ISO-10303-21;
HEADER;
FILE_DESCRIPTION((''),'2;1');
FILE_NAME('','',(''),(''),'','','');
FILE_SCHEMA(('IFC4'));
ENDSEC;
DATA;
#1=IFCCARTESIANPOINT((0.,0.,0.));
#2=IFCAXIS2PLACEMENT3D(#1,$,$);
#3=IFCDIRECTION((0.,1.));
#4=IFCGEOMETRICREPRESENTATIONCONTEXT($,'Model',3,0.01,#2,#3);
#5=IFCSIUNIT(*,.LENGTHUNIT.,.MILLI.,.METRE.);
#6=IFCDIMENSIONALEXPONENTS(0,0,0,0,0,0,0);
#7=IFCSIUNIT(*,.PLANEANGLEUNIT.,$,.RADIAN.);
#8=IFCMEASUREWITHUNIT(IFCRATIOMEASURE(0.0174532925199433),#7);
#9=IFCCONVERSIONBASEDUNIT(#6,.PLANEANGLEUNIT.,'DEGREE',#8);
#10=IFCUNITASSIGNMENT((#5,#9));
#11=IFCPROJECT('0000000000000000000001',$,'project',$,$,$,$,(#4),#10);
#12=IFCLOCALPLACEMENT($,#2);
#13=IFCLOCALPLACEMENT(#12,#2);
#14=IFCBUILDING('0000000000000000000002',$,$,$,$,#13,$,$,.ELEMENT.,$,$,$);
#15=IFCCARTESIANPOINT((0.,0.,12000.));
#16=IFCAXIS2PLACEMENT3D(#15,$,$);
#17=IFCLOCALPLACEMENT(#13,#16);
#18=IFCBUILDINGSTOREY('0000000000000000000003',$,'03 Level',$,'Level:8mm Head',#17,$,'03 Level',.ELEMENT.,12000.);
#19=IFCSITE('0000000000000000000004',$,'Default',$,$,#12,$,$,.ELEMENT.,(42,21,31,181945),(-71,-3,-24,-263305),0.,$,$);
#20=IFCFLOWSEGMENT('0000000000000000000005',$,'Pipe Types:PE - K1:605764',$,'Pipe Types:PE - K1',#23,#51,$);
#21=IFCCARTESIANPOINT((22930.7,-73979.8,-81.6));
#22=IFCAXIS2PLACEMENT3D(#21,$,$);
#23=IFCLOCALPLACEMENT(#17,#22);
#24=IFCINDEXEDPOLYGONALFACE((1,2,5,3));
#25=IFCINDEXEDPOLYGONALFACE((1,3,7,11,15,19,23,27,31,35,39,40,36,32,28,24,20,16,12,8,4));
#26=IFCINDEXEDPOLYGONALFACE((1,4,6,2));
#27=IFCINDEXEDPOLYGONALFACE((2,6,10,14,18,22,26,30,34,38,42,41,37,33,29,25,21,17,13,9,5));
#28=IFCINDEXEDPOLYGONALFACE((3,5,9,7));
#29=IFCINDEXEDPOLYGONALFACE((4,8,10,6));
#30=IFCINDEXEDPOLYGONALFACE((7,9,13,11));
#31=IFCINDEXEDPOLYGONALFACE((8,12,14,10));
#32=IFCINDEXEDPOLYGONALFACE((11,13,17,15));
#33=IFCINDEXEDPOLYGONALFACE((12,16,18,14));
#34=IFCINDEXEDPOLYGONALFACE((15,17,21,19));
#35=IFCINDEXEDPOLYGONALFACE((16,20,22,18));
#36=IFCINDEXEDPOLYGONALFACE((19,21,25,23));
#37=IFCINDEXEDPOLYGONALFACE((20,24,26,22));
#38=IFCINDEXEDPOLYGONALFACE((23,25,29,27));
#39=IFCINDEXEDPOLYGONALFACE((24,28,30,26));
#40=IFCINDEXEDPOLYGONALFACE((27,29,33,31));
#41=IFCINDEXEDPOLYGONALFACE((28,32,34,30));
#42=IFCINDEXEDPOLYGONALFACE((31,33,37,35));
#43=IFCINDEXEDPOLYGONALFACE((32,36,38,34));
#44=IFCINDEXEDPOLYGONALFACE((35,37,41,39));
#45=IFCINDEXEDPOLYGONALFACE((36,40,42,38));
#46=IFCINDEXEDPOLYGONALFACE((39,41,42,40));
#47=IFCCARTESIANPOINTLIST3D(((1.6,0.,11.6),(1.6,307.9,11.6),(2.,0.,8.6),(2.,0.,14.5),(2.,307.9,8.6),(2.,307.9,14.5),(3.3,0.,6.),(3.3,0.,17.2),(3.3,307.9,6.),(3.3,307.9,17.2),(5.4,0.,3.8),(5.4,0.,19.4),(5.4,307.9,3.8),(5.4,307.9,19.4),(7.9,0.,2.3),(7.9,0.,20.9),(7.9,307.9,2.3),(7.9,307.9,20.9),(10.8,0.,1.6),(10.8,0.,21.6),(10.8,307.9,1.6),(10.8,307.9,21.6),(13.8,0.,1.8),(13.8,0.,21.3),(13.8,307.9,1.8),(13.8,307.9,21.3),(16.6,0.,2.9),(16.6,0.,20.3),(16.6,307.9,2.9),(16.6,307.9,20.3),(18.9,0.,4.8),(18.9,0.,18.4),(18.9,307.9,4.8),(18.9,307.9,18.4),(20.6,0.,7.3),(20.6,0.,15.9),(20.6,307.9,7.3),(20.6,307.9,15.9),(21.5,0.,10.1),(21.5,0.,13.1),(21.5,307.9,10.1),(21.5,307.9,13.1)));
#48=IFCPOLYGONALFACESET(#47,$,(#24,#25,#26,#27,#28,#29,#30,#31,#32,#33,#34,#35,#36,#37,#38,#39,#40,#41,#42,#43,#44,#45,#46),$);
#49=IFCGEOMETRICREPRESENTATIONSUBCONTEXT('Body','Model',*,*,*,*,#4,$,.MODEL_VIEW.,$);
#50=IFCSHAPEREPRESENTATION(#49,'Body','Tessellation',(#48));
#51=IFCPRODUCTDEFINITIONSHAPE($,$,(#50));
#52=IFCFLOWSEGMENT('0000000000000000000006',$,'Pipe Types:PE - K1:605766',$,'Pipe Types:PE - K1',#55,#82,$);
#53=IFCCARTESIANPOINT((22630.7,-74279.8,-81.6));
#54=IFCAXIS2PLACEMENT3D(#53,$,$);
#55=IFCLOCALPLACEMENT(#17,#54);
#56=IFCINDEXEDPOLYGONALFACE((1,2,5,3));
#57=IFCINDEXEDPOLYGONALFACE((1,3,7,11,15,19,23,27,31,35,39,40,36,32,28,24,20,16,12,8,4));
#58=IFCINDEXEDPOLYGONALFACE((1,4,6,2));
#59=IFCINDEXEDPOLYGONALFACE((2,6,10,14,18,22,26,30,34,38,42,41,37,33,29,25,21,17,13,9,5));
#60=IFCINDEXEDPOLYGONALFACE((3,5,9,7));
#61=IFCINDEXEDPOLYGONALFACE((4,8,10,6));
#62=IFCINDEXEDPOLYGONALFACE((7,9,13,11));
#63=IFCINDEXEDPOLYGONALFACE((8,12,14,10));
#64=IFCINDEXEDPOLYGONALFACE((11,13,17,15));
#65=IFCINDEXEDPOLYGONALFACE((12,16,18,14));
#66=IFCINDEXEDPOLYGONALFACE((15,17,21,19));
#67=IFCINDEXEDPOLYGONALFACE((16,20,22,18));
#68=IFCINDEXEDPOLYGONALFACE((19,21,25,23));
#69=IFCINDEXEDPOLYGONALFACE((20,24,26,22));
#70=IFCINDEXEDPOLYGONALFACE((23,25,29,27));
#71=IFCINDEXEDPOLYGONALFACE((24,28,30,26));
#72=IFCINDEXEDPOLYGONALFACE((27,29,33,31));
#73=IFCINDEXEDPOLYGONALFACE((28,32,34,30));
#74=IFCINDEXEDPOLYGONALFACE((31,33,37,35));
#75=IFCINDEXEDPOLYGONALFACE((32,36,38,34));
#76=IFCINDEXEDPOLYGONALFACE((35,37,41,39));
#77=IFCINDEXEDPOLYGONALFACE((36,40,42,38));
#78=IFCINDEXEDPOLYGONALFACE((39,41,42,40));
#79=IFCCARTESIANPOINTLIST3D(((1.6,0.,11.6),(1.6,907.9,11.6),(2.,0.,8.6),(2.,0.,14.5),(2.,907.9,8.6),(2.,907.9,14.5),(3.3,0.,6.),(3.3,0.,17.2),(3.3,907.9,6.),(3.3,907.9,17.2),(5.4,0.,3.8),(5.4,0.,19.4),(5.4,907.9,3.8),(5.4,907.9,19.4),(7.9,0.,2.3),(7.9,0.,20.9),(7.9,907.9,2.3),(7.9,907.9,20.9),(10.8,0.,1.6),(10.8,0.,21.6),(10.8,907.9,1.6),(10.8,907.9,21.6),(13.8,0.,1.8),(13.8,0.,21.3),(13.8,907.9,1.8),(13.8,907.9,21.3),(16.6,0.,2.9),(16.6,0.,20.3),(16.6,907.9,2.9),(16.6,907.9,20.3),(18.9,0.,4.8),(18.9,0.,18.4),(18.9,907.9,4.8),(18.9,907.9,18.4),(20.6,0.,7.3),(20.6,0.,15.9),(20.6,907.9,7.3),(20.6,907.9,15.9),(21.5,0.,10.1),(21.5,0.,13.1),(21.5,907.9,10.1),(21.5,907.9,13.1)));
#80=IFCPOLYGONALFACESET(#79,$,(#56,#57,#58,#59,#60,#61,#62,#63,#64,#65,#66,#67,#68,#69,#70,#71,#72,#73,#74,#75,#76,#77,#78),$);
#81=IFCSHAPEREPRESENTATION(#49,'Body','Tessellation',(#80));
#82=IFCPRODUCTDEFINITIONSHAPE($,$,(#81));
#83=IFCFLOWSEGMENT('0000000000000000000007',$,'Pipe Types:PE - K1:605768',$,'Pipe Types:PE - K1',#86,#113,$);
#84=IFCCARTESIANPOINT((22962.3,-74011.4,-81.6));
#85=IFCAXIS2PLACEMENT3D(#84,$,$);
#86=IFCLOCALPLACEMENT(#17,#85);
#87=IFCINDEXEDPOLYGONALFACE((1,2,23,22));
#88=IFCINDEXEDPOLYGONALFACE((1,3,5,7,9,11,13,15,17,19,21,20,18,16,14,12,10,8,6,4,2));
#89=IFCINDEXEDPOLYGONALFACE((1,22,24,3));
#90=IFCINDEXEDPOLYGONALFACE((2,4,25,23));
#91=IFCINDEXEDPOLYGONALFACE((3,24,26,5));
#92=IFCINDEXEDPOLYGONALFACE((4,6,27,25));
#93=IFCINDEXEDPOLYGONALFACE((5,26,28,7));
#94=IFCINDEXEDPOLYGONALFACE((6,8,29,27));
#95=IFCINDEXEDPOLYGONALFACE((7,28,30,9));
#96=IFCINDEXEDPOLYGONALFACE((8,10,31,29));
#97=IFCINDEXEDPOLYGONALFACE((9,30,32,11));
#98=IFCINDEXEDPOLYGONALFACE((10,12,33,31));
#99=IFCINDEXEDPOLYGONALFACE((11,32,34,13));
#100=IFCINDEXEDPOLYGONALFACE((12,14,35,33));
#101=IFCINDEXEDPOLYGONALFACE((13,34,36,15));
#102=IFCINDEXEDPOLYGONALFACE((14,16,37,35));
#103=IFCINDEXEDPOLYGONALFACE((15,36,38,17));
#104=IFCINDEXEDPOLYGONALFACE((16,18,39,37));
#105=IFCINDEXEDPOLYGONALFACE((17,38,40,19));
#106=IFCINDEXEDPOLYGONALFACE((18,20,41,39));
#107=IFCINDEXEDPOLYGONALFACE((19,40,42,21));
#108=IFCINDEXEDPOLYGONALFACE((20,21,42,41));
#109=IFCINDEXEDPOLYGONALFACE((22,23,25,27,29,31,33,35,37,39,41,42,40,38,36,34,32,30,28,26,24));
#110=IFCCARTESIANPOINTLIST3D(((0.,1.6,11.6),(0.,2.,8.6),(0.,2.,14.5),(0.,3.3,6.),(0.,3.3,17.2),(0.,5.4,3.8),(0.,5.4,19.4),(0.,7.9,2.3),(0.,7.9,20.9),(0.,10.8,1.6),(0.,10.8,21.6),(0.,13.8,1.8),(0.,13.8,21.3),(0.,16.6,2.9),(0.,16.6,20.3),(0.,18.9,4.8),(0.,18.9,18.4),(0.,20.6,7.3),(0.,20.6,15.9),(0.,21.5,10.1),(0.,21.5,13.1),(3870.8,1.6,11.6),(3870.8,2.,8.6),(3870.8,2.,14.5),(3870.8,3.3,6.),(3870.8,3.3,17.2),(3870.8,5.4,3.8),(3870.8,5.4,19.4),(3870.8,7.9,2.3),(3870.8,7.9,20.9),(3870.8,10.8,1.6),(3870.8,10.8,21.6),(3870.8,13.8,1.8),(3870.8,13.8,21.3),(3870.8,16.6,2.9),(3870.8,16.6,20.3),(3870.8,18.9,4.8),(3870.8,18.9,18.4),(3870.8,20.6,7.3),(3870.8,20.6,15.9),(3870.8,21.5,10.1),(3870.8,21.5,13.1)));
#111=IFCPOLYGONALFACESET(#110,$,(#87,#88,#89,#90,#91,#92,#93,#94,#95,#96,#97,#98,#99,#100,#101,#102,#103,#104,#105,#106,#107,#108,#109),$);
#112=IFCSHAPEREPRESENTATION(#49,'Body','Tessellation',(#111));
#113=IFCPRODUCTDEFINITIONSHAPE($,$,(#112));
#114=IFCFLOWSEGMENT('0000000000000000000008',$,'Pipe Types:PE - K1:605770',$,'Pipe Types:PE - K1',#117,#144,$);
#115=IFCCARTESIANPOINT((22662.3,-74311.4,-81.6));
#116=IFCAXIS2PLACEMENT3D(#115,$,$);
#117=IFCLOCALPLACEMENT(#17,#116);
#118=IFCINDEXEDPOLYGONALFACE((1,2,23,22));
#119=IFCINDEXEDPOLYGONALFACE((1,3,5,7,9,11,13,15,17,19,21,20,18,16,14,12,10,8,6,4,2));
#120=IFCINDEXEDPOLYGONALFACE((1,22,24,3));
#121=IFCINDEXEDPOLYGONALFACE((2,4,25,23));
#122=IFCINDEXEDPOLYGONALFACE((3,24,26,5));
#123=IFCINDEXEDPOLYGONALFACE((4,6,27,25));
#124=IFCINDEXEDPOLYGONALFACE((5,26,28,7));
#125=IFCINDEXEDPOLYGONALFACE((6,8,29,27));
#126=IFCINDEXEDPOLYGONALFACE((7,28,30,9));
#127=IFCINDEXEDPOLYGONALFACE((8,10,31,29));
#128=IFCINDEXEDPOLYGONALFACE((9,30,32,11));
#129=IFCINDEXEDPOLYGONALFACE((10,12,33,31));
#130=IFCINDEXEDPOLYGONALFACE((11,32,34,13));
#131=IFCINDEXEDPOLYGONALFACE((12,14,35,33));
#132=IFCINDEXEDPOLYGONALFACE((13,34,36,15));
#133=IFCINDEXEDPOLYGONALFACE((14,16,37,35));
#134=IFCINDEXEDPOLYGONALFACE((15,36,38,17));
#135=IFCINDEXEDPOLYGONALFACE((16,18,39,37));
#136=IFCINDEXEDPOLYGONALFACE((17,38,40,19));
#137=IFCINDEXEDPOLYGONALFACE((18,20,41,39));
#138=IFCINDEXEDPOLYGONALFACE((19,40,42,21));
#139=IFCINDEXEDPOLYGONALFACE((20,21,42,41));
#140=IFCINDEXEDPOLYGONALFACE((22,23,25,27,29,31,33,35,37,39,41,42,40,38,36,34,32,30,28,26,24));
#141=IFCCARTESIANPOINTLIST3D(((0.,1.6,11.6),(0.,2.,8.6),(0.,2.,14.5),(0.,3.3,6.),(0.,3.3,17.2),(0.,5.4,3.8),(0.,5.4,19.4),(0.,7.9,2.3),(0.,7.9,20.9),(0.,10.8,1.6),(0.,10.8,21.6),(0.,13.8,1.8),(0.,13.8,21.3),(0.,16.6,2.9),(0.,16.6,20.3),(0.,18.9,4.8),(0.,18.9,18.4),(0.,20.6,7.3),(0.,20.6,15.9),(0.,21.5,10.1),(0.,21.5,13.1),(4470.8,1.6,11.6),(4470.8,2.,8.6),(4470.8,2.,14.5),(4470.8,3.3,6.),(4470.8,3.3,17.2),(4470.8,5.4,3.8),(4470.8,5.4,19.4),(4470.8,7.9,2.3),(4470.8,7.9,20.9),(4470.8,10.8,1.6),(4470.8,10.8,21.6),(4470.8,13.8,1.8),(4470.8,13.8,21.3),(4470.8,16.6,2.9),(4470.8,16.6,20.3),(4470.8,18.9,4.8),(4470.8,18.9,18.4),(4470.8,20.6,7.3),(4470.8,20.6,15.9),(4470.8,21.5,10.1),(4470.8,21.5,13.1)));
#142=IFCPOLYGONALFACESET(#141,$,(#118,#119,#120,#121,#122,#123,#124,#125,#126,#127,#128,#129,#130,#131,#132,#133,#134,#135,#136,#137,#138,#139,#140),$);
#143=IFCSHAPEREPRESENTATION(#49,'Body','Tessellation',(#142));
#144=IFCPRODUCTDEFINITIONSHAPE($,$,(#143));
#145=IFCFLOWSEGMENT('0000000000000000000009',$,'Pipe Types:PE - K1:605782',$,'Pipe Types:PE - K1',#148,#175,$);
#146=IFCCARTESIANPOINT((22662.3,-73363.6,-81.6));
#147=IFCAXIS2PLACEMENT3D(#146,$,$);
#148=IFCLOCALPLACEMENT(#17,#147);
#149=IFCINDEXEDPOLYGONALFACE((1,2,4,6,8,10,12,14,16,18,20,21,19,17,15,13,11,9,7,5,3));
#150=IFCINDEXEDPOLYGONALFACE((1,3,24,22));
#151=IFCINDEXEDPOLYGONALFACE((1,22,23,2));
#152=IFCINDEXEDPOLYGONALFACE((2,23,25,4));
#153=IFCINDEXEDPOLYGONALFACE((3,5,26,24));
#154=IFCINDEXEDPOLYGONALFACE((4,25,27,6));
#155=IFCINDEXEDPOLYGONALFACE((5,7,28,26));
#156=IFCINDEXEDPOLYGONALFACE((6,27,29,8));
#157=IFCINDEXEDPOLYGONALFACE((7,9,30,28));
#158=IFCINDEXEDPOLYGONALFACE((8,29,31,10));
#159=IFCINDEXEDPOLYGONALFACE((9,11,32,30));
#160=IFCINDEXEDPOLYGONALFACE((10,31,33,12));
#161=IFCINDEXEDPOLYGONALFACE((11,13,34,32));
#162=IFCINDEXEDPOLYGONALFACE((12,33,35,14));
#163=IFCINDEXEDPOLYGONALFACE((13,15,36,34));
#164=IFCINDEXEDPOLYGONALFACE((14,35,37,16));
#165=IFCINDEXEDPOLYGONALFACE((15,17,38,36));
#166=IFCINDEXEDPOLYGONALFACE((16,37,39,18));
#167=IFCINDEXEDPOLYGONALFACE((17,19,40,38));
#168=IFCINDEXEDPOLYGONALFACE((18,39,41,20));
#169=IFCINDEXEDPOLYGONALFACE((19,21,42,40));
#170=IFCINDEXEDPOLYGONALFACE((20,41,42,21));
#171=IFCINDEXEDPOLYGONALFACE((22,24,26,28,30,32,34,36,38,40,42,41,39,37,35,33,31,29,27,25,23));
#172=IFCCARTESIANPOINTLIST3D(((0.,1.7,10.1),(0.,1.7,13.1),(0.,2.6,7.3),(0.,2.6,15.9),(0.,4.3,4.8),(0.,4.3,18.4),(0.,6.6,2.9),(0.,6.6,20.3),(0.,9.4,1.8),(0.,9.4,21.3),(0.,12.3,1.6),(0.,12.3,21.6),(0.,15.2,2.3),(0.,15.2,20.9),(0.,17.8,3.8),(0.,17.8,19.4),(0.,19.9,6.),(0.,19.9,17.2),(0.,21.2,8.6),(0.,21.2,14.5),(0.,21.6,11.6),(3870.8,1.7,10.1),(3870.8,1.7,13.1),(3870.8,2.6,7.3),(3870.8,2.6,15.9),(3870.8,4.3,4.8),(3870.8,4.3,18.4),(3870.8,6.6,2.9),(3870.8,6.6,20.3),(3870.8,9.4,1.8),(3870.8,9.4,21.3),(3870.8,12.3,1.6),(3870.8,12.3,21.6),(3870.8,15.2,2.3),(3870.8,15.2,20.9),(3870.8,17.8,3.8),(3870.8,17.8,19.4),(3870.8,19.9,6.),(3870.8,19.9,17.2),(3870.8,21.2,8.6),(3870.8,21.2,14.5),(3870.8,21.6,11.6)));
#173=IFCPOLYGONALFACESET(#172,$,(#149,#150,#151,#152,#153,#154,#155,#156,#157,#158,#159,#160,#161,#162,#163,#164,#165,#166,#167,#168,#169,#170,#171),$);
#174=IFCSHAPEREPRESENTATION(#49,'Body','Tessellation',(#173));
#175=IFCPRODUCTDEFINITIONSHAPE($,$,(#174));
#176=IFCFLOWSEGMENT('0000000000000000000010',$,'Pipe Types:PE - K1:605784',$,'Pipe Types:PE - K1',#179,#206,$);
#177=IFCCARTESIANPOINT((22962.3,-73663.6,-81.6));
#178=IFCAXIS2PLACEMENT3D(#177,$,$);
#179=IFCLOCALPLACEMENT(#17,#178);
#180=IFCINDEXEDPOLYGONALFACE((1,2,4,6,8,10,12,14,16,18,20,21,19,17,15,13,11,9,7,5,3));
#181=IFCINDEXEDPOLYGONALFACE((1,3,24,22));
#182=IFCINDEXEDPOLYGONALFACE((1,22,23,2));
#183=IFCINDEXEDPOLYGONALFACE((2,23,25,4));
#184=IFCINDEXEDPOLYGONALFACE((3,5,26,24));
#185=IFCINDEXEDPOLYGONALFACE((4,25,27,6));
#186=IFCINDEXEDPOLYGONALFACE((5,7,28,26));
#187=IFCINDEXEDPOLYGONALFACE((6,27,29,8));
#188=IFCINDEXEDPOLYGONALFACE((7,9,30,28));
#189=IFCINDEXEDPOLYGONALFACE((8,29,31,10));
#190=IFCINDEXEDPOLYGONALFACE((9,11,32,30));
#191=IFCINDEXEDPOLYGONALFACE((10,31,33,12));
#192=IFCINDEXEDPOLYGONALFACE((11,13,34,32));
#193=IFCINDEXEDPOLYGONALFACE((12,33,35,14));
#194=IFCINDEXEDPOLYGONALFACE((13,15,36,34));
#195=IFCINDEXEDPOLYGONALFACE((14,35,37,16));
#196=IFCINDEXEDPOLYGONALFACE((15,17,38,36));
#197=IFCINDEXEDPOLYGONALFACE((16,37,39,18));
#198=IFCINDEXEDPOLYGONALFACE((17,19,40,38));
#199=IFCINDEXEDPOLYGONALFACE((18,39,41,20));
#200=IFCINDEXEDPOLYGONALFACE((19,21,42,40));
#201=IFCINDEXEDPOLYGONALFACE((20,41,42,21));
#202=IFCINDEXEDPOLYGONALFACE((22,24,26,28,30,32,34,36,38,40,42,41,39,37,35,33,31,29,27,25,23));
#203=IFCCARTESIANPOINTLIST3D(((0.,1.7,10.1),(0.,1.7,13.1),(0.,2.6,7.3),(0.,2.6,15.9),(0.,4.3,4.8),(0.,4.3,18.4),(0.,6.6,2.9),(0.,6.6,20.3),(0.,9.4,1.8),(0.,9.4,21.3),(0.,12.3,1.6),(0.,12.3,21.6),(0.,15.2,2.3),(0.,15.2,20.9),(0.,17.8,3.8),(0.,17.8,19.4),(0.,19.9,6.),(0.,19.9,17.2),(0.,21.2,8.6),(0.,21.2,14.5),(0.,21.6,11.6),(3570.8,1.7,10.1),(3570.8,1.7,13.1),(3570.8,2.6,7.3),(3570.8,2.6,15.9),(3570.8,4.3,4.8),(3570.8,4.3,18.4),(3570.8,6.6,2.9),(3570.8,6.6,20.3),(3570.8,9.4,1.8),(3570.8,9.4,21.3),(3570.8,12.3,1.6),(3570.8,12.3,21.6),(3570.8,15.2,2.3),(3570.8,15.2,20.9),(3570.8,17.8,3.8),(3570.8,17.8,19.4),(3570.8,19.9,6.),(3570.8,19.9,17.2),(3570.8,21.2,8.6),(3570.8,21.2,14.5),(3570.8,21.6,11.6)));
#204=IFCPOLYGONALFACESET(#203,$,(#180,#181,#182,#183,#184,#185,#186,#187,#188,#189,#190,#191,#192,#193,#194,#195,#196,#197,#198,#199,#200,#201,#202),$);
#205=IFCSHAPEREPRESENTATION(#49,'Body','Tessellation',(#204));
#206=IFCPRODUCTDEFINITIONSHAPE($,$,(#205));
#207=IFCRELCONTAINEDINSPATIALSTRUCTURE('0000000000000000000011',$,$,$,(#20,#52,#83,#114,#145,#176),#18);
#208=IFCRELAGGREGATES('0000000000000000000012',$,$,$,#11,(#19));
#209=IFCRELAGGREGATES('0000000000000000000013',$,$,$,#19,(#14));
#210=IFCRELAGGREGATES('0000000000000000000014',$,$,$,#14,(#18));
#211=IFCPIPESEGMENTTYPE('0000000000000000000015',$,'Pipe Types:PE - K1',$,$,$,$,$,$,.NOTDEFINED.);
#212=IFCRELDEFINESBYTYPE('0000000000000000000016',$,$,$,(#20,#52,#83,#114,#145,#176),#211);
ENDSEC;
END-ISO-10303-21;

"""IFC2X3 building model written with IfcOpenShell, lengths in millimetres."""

from ifc_helpers import new_model, entity, si_unit, converted_unit, direction, frame, frame_2d, origin, origin_2d_with_axis, place, context, subcontext, project, spatial, circle, extrude, type_object, element, save


model = new_model("IFC2X3")

# Units and contexts
model_context = context("Model", 3, precision=0.01, world=origin(), true_north=direction((0.0, 1.0)))
body_context = subcontext(model_context, "Body", "Model", "MODEL_VIEW")
ifc_project = project(units=[si_unit("LENGTHUNIT", "METRE", prefix="MILLI"), converted_unit("PLANEANGLEUNIT", "DEGREE", entity("IfcRatioMeasure", 0.0174532925199433), si_unit("PLANEANGLEUNIT", "RADIAN"), dimensions=[0, 0, 0, 0, 0, 0, 0])], contexts=[model_context])

# Site, building, storey
site_placement = place(None, origin())
site = spatial("IfcSite", under=ifc_project, at=site_placement, Name="Default", CompositionType="ELEMENT", RefLatitude=(42, 21, 31, 181945), RefLongitude=(-71, -3, -24, -263305), RefElevation=0.0)
building_placement = place(site_placement, origin())
building = spatial("IfcBuilding", under=site, at=building_placement, CompositionType="ELEMENT")
storey_placement = place(building_placement, frame((0.0, 0.0, 12000.0)))
storey = spatial("IfcBuildingStorey", under=building, at=storey_placement, Name="03 Level", ObjectType="Level:8mm Head", LongName="03 Level", CompositionType="ELEMENT", Elevation=12000.0)

# Flow segments
pipe_segment_type = type_object("IfcPipeSegmentType", Name="Pipe Types:PE - K1", PredefinedType="NOTDEFINED")
flow_segment_1_placement = place(storey_placement, frame((22930.7, -73979.8, -81.6)))
element("IfcFlowSegment", 1, at=flow_segment_1_placement, inside=storey, type_object=pipe_segment_type, Name="Pipe Types:PE - K1:605764", ObjectType="Pipe Types:PE - K1", context=body_context, shape_type="SweptSolid", body=[
    extrude(circle(Radius=10.0, at=frame_2d((0.0, 0.0), x_axis=(1.0, 0.0))), frame((11.6, 0.0, 11.6), z_axis=(0.0, 1.0, 0.0), x_axis=(-1.0, 0.0, 0.0)), (0.0, 0.0, 1.0), 307.9),
])
flow_segment_2_placement = place(storey_placement, frame((22630.7, -74279.8, -81.6)))
element("IfcFlowSegment", 2, at=flow_segment_2_placement, inside=storey, type_object=pipe_segment_type, Name="Pipe Types:PE - K1:605766", ObjectType="Pipe Types:PE - K1", context=body_context, shape_type="SweptSolid", body=[
    extrude(circle(Radius=10.0, at=frame_2d((0.0, 0.0), x_axis=(1.0, 0.0))), frame((11.6, 0.0, 11.6), z_axis=(0.0, 1.0, 0.0), x_axis=(-1.0, 0.0, 0.0)), (0.0, 0.0, 1.0), 907.9),
])
flow_segment_3_placement = place(storey_placement, frame((22962.3, -74011.4, -81.6)))
element("IfcFlowSegment", 3, at=flow_segment_3_placement, inside=storey, type_object=pipe_segment_type, Name="Pipe Types:PE - K1:605768", ObjectType="Pipe Types:PE - K1", context=body_context, shape_type="SweptSolid", body=[
    extrude(circle(Radius=10.0, at=origin_2d_with_axis()), frame((0.0, 11.6, 11.6), z_axis=(1.0, 0.0, 0.0), x_axis=(0.0, -1.0, 0.0)), (0.0, 0.0, 1.0), 3870.8),
])
flow_segment_4_placement = place(storey_placement, frame((22662.3, -74311.4, -81.6)))
element("IfcFlowSegment", 4, at=flow_segment_4_placement, inside=storey, type_object=pipe_segment_type, Name="Pipe Types:PE - K1:605770", ObjectType="Pipe Types:PE - K1", context=body_context, shape_type="SweptSolid", body=[
    extrude(circle(Radius=10.0, at=origin_2d_with_axis()), frame((0.0, 11.6, 11.6), z_axis=(1.0, 0.0, 0.0), x_axis=(0.0, -1.0, 0.0)), (0.0, 0.0, 1.0), 4470.8),
])
flow_segment_5_placement = place(storey_placement, frame((22662.3, -73363.6, -81.6)))
element("IfcFlowSegment", 5, at=flow_segment_5_placement, inside=storey, type_object=pipe_segment_type, Name="Pipe Types:PE - K1:605782", ObjectType="Pipe Types:PE - K1", context=body_context, shape_type="SweptSolid", body=[
    extrude(circle(Radius=10.0, at=frame_2d((0.0, 0.0), x_axis=(1.0, 0.0))), frame((0.0, 11.6, 11.6), z_axis=(1.0, 0.0, 0.0), x_axis=(0.0, 1.0, 0.0)), (0.0, 0.0, 1.0), 3870.8),
])
flow_segment_6_placement = place(storey_placement, frame((22962.3, -73663.6, -81.6)))
element("IfcFlowSegment", 6, at=flow_segment_6_placement, inside=storey, type_object=pipe_segment_type, Name="Pipe Types:PE - K1:605784", ObjectType="Pipe Types:PE - K1", context=body_context, shape_type="SweptSolid", body=[
    extrude(circle(Radius=10.0, at=frame_2d((0.0, 0.0), x_axis=(1.0, 0.0))), frame((0.0, 11.6, 11.6), z_axis=(1.0, 0.0, 0.0), x_axis=(0.0, 1.0, 0.0)), (0.0, 0.0, 1.0), 3570.8),
])

save(model, "model.ifc")
